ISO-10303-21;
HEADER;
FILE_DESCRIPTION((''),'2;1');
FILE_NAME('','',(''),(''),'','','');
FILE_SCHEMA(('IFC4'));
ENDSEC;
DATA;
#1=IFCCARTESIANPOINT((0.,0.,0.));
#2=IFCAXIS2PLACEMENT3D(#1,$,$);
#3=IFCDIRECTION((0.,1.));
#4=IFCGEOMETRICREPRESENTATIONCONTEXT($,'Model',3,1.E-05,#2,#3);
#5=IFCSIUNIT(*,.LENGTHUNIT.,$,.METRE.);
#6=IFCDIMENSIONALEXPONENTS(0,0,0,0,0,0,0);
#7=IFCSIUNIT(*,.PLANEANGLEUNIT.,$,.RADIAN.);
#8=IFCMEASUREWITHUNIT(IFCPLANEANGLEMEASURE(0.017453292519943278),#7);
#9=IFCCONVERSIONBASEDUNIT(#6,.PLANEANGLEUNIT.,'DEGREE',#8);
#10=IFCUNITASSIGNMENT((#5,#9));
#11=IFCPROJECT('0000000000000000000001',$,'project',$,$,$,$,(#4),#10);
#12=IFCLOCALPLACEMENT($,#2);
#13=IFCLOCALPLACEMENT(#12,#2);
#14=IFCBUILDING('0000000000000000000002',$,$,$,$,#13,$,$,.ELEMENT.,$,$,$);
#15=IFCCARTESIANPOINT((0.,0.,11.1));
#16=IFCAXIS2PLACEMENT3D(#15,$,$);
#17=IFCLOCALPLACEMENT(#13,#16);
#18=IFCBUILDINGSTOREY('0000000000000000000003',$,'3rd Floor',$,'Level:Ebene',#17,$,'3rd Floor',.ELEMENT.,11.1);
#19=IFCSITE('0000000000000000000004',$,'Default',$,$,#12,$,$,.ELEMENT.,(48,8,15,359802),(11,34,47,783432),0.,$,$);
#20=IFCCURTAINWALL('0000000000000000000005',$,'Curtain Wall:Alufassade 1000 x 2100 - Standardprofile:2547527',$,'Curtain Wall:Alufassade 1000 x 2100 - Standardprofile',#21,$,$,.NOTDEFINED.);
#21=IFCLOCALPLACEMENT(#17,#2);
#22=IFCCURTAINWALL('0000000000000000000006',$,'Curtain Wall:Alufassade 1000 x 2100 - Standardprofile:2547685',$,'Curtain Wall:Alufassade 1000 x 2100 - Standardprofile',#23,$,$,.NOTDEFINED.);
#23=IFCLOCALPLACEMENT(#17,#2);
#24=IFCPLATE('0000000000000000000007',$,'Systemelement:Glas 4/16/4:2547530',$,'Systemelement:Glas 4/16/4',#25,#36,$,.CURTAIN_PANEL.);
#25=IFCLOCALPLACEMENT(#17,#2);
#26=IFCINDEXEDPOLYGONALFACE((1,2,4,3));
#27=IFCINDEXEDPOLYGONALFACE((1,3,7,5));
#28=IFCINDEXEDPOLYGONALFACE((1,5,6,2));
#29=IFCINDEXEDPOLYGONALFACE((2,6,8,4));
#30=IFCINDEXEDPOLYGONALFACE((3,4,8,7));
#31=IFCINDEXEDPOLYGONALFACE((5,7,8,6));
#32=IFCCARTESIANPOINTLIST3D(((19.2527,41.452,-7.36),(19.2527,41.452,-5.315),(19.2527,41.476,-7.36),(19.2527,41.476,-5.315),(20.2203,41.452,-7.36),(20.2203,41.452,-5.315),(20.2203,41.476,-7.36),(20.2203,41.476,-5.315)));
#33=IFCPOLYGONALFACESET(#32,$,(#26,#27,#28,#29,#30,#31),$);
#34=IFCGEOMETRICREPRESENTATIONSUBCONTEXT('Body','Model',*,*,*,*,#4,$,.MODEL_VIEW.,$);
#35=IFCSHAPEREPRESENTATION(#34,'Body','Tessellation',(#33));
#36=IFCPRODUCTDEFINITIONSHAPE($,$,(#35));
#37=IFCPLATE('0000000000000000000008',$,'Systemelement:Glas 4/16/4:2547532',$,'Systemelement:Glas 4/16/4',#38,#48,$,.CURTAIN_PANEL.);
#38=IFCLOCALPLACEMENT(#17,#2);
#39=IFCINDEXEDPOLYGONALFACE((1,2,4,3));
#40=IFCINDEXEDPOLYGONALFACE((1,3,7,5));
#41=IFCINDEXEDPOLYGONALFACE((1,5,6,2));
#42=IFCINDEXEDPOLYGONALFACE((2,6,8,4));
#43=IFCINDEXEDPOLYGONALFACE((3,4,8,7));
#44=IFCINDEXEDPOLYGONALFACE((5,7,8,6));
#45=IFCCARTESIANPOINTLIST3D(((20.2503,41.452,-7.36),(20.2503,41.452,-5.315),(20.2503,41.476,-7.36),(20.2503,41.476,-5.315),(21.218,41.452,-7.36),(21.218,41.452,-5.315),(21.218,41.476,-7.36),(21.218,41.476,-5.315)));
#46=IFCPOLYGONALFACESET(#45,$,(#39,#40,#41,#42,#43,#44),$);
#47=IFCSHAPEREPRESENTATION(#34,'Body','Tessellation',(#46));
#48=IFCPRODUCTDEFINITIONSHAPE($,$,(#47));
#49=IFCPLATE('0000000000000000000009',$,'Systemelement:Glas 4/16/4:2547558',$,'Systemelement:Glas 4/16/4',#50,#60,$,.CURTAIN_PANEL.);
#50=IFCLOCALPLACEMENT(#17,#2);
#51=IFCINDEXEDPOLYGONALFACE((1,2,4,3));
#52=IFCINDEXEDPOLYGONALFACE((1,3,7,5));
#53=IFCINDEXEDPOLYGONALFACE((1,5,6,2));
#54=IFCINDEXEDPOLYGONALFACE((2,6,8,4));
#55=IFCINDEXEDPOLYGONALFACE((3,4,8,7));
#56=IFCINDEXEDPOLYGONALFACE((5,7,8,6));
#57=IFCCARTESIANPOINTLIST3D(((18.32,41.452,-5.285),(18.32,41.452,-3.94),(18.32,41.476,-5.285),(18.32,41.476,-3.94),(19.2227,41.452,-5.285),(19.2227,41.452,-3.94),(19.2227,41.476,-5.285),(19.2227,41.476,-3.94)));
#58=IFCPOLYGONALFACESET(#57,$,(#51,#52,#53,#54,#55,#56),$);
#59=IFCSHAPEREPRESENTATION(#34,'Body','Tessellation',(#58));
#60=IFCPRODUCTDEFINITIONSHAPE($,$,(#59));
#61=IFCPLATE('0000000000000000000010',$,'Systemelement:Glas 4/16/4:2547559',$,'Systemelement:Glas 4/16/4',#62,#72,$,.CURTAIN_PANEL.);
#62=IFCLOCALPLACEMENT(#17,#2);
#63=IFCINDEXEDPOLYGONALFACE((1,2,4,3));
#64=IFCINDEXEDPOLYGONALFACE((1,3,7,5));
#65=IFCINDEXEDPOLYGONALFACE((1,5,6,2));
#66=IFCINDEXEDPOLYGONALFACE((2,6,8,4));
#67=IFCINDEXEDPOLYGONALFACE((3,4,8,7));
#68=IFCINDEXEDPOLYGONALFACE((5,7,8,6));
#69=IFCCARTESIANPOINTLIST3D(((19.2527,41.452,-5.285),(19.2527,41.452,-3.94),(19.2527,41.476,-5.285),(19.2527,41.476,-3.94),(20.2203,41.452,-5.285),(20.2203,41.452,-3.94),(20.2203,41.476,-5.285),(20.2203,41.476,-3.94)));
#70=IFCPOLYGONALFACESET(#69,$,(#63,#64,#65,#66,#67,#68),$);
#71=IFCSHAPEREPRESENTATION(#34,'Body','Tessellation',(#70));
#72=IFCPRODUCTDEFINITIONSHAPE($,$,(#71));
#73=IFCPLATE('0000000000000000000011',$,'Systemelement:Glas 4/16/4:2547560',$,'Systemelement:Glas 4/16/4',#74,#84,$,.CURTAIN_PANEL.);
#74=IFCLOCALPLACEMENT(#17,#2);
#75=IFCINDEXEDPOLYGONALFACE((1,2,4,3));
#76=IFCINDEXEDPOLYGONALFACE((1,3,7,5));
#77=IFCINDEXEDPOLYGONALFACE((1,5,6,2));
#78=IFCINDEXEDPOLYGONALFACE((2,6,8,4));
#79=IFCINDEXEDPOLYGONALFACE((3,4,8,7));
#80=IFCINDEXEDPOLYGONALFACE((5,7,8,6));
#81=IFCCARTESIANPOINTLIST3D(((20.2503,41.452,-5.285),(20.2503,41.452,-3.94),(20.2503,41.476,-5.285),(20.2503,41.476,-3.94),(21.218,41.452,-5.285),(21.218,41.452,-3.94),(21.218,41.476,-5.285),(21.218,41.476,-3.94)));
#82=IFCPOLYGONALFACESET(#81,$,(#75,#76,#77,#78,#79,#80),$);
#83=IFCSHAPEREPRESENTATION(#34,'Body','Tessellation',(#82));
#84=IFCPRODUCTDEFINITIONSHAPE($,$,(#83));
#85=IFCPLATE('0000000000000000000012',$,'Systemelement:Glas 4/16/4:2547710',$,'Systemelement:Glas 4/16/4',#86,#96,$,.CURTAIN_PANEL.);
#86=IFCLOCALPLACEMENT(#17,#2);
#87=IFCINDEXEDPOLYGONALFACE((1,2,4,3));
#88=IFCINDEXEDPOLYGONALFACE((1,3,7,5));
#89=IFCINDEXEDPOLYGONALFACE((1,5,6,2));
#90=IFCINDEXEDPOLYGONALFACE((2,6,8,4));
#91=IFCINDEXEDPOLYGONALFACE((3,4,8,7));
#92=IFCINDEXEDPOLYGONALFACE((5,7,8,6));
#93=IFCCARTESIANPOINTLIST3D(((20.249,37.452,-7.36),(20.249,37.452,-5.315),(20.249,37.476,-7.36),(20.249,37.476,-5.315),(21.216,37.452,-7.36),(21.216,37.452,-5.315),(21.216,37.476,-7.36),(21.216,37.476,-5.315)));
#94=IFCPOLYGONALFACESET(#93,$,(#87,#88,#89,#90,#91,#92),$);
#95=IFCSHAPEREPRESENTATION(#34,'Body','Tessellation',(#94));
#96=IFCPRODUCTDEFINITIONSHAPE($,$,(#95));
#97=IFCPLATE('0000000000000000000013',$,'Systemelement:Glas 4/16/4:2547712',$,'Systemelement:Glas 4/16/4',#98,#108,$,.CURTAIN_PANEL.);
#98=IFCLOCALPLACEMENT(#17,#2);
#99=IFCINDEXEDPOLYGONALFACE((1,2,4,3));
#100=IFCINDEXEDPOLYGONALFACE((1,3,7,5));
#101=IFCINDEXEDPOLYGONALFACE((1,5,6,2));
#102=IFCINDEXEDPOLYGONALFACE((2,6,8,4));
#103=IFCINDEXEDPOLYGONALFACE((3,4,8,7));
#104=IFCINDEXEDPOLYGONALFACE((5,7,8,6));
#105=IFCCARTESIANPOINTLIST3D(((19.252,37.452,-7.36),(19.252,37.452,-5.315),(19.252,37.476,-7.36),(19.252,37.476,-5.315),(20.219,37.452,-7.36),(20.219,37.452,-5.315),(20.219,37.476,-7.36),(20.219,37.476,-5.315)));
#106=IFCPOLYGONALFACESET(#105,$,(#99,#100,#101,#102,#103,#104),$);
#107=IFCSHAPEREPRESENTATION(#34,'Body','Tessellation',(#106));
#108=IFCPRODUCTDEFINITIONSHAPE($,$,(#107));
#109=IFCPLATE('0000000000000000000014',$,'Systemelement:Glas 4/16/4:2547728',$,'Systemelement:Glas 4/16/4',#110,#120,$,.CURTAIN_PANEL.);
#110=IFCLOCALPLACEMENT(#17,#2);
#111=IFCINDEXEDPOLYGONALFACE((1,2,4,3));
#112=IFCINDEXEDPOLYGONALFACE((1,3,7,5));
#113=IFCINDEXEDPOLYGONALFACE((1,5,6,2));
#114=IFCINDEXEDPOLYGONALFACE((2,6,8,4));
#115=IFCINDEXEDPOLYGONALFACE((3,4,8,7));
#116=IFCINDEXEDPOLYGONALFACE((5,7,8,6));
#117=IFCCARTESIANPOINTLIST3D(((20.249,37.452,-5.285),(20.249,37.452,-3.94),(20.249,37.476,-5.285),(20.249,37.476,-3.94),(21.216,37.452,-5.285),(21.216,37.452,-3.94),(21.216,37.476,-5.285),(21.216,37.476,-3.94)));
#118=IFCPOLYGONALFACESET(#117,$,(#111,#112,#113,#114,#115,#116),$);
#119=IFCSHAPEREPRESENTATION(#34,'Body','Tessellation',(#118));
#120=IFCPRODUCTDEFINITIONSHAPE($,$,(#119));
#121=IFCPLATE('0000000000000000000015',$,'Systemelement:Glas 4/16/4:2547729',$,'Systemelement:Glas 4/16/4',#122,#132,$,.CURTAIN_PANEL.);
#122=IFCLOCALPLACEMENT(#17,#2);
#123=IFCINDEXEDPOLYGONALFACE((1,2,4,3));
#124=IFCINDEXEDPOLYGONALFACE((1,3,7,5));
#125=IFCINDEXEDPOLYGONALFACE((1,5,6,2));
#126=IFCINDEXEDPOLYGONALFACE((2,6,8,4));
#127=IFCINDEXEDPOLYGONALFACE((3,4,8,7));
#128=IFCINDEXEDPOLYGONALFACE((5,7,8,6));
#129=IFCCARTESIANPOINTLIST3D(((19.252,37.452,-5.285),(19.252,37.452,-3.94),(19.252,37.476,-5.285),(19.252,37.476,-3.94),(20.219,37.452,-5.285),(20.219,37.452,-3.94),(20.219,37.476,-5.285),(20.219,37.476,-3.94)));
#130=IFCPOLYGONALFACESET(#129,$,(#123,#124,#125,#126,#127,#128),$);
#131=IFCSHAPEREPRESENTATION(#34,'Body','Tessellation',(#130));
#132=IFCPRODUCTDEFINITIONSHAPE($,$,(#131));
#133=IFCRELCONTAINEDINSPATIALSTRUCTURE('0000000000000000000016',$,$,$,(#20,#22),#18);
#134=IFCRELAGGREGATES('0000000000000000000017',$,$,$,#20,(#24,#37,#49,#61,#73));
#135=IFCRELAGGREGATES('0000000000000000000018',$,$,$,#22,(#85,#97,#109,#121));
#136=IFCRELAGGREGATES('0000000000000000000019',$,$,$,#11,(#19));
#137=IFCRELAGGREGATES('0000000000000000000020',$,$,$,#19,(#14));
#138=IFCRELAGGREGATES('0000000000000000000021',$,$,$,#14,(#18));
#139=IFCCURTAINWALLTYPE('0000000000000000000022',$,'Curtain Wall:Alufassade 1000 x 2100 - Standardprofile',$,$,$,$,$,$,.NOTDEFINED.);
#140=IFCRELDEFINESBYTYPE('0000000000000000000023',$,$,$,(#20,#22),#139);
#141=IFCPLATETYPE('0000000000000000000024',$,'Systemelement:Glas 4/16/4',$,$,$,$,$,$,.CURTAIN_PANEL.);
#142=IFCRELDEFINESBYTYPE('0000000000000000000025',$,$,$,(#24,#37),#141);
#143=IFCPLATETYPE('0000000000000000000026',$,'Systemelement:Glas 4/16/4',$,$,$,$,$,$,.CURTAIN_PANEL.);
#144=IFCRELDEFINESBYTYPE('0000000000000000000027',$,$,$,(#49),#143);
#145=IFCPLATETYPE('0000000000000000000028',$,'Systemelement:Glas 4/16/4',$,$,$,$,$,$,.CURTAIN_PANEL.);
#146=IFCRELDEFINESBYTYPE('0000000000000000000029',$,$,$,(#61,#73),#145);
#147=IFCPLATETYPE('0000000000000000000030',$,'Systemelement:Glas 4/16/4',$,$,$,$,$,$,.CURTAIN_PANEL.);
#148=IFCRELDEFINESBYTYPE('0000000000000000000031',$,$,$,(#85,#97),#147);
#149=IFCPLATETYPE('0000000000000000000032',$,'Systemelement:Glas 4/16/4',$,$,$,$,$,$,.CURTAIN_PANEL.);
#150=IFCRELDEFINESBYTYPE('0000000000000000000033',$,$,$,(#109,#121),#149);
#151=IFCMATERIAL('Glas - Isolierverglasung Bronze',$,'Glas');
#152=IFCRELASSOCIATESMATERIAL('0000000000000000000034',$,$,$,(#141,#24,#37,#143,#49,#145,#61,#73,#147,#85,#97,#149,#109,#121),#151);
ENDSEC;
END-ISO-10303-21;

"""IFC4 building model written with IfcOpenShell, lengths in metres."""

from ifc_helpers import new_model, entity, si_unit, converted_unit, direction, frame, origin, place, context, subcontext, project, spatial, indexed_curve, outline, extrude, source, transform, mapped, material, type_object, type_shapes, element, aggregate, save


model = new_model("IFC4")

# Units and contexts
model_context = context("Model", 3, precision=1e-05, world=origin(), true_north=direction((0.0, 1.0)))
body_context = subcontext(model_context, "Body", "Model", "MODEL_VIEW")
ifc_project = project(units=[si_unit("LENGTHUNIT", "METRE"), converted_unit("PLANEANGLEUNIT", "DEGREE", entity("IfcPlaneAngleMeasure", 0.017453292519943278), si_unit("PLANEANGLEUNIT", "RADIAN"), dimensions=[0, 0, 0, 0, 0, 0, 0])], contexts=[model_context])

# Site, building, storey
site_placement = place(None, origin())
site = spatial("IfcSite", under=ifc_project, at=site_placement, Name="Default", CompositionType="ELEMENT", RefLatitude=(48, 8, 15, 359802), RefLongitude=(11, 34, 47, 783432), RefElevation=0.0)
building_placement = place(site_placement, origin())
building = spatial("IfcBuilding", under=site, at=building_placement, CompositionType="ELEMENT")
storey_placement = place(building_placement, frame((0.0, 0.0, 11.1)))
storey = spatial("IfcBuildingStorey", under=building, at=storey_placement, Name="3rd Floor", ObjectType="Level:Ebene", LongName="3rd Floor", CompositionType="ELEMENT", Elevation=11.1)

# Curtain walls
curtain_wall_type = type_object("IfcCurtainWallType", Name="Curtain Wall:Alufassade 1000 x 2100 - Standardprofile", PredefinedType="NOTDEFINED")
curtain_wall_1_placement = place(storey_placement, frame((0.0, 0.0, -11.1)))
curtain_wall_1 = element("IfcCurtainWall", 1, at=curtain_wall_1_placement, inside=storey, type_object=curtain_wall_type, Name="Curtain Wall:Alufassade 1000 x 2100 - Standardprofile:2547527", ObjectType="Curtain Wall:Alufassade 1000 x 2100 - Standardprofile", PredefinedType="NOTDEFINED")
curtain_wall_2_placement = place(storey_placement, frame((0.0, 0.0, -11.1)))
curtain_wall_2 = element("IfcCurtainWall", 2, at=curtain_wall_2_placement, inside=storey, type_object=curtain_wall_type, Name="Curtain Wall:Alufassade 1000 x 2100 - Standardprofile:2547685", ObjectType="Curtain Wall:Alufassade 1000 x 2100 - Standardprofile", PredefinedType="NOTDEFINED")

# Plates
ifc_material_1 = material(Name="Glas - Isolierverglasung Bronze", Category="Glas")
plate_type_1 = type_object("IfcPlateType", Name="Systemelement:Glas 4/16/4", PredefinedType="CURTAIN_PANEL", material=ifc_material_1)
shared_shape_1 = source(origin(), body_context, "Body", "SweptSolid", [
    extrude(outline(indexed_curve([(-0.012, -0.4838), (0.012, -0.4838), (0.012, 0.4838), (-0.012, 0.4838), (-0.012, -0.4838)], self_intersect=False)), frame((0.0, 0.0, 0.0), z_axis=(0.0, 0.0, 1.0), x_axis=(0.0, 1.0, 0.0)), (0.0, 0.0, 1.0), 2.045),
])
type_shapes(plate_type_1, [shared_shape_1])
plate_1_placement = place(curtain_wall_1_placement, frame((19.7365, 41.464, 3.74)))
plate_1 = element("IfcPlate", 3, at=plate_1_placement, type_object=plate_type_1, material=ifc_material_1, Name="Systemelement:Glas 4/16/4:2547530", ObjectType="Systemelement:Glas 4/16/4", PredefinedType="CURTAIN_PANEL", context=body_context, shape_type="MappedRepresentation", body=[
    mapped(shared_shape_1, transform((0.0, 0.0, 0.0), scale=1.0)),
])
plate_2_placement = place(curtain_wall_1_placement, frame((20.7342, 41.464, 3.74)))
plate_2 = element("IfcPlate", 4, at=plate_2_placement, type_object=plate_type_1, material=ifc_material_1, Name="Systemelement:Glas 4/16/4:2547532", ObjectType="Systemelement:Glas 4/16/4", PredefinedType="CURTAIN_PANEL", context=body_context, shape_type="MappedRepresentation", body=[
    mapped(shared_shape_1, transform((0.0, 0.0, 0.0), scale=1.0)),
])
plate_type_2 = type_object("IfcPlateType", Name="Systemelement:Glas 4/16/4", PredefinedType="CURTAIN_PANEL", material=ifc_material_1)
shared_shape_2 = source(origin(), body_context, "Body", "SweptSolid", [
    extrude(outline(indexed_curve([(-0.012, -0.4513), (0.012, -0.4513), (0.012, 0.4513), (-0.012, 0.4513), (-0.012, -0.4513)], self_intersect=False)), frame((0.0, 0.0, 0.0), z_axis=(0.0, 0.0, 1.0), x_axis=(0.0, 1.0, 0.0)), (0.0, 0.0, 1.0), 1.345),
])
type_shapes(plate_type_2, [shared_shape_2])
plate_3_placement = place(curtain_wall_1_placement, frame((18.7713, 41.464, 5.815)))
plate_3 = element("IfcPlate", 5, at=plate_3_placement, type_object=plate_type_2, material=ifc_material_1, Name="Systemelement:Glas 4/16/4:2547558", ObjectType="Systemelement:Glas 4/16/4", PredefinedType="CURTAIN_PANEL", context=body_context, shape_type="MappedRepresentation", body=[
    mapped(shared_shape_2, transform((0.0, 0.0, 0.0), scale=1.0)),
])
plate_type_3 = type_object("IfcPlateType", Name="Systemelement:Glas 4/16/4", PredefinedType="CURTAIN_PANEL", material=ifc_material_1)
shared_shape_3 = source(origin(), body_context, "Body", "SweptSolid", [
    extrude(outline(indexed_curve([(-0.012, -0.4838), (0.012, -0.4838), (0.012, 0.4838), (-0.012, 0.4838), (-0.012, -0.4838)], self_intersect=False)), frame((0.0, 0.0, 0.0), z_axis=(0.0, 0.0, 1.0), x_axis=(0.0, 1.0, 0.0)), (0.0, 0.0, 1.0), 1.345),
])
type_shapes(plate_type_3, [shared_shape_3])
plate_4_placement = place(curtain_wall_1_placement, frame((19.7365, 41.464, 5.815)))
plate_4 = element("IfcPlate", 6, at=plate_4_placement, type_object=plate_type_3, material=ifc_material_1, Name="Systemelement:Glas 4/16/4:2547559", ObjectType="Systemelement:Glas 4/16/4", PredefinedType="CURTAIN_PANEL", context=body_context, shape_type="MappedRepresentation", body=[
    mapped(shared_shape_3, transform((0.0, 0.0, 0.0), scale=1.0)),
])
plate_5_placement = place(curtain_wall_1_placement, frame((20.7342, 41.464, 5.815)))
plate_5 = element("IfcPlate", 7, at=plate_5_placement, type_object=plate_type_3, material=ifc_material_1, Name="Systemelement:Glas 4/16/4:2547560", ObjectType="Systemelement:Glas 4/16/4", PredefinedType="CURTAIN_PANEL", context=body_context, shape_type="MappedRepresentation", body=[
    mapped(shared_shape_3, transform((0.0, 0.0, 0.0), scale=1.0)),
])
aggregate(curtain_wall_1, [plate_1, plate_2, plate_3, plate_4, plate_5])
plate_type_4 = type_object("IfcPlateType", Name="Systemelement:Glas 4/16/4", PredefinedType="CURTAIN_PANEL", material=ifc_material_1)
shared_shape_4 = source(origin(), body_context, "Body", "SweptSolid", [
    extrude(outline(indexed_curve([(-0.012, -0.4835), (0.012, -0.4835), (0.012, 0.4835), (-0.012, 0.4835), (-0.012, -0.4835)], self_intersect=False)), frame((0.0, 0.0, 0.0), z_axis=(0.0, 0.0, 1.0), x_axis=(0.0, 1.0, 0.0)), (0.0, 0.0, 1.0), 2.045),
])
type_shapes(plate_type_4, [shared_shape_4])
plate_6_placement = place(curtain_wall_2_placement, frame((20.7325, 37.464, 3.74), z_axis=(0.0, 0.0, 1.0), x_axis=(-1.0, 0.0, 0.0)))
plate_6 = element("IfcPlate", 8, at=plate_6_placement, type_object=plate_type_4, material=ifc_material_1, Name="Systemelement:Glas 4/16/4:2547710", ObjectType="Systemelement:Glas 4/16/4", PredefinedType="CURTAIN_PANEL", context=body_context, shape_type="MappedRepresentation", body=[
    mapped(shared_shape_4, transform((0.0, 0.0, 0.0), scale=1.0)),
])
plate_7_placement = place(curtain_wall_2_placement, frame((19.7355, 37.464, 3.74), z_axis=(0.0, 0.0, 1.0), x_axis=(-1.0, 0.0, 0.0)))
plate_7 = element("IfcPlate", 9, at=plate_7_placement, type_object=plate_type_4, material=ifc_material_1, Name="Systemelement:Glas 4/16/4:2547712", ObjectType="Systemelement:Glas 4/16/4", PredefinedType="CURTAIN_PANEL", context=body_context, shape_type="MappedRepresentation", body=[
    mapped(shared_shape_4, transform((0.0, 0.0, 0.0), scale=1.0)),
])
plate_type_5 = type_object("IfcPlateType", Name="Systemelement:Glas 4/16/4", PredefinedType="CURTAIN_PANEL", material=ifc_material_1)
shared_shape_5 = source(origin(), body_context, "Body", "SweptSolid", [
    extrude(outline(indexed_curve([(-0.012, -0.4835), (0.012, -0.4835), (0.012, 0.4835), (-0.012, 0.4835), (-0.012, -0.4835)], self_intersect=False)), frame((0.0, 0.0, 0.0), z_axis=(0.0, 0.0, 1.0), x_axis=(0.0, 1.0, 0.0)), (0.0, 0.0, 1.0), 1.345),
])
type_shapes(plate_type_5, [shared_shape_5])
plate_8_placement = place(curtain_wall_2_placement, frame((20.7325, 37.464, 5.815), z_axis=(0.0, 0.0, 1.0), x_axis=(-1.0, 0.0, 0.0)))
plate_8 = element("IfcPlate", 10, at=plate_8_placement, type_object=plate_type_5, material=ifc_material_1, Name="Systemelement:Glas 4/16/4:2547728", ObjectType="Systemelement:Glas 4/16/4", PredefinedType="CURTAIN_PANEL", context=body_context, shape_type="MappedRepresentation", body=[
    mapped(shared_shape_5, transform((0.0, 0.0, 0.0), scale=1.0)),
])
plate_9_placement = place(curtain_wall_2_placement, frame((19.7355, 37.464, 5.815), z_axis=(0.0, 0.0, 1.0), x_axis=(-1.0, 0.0, 0.0)))
plate_9 = element("IfcPlate", 11, at=plate_9_placement, type_object=plate_type_5, material=ifc_material_1, Name="Systemelement:Glas 4/16/4:2547729", ObjectType="Systemelement:Glas 4/16/4", PredefinedType="CURTAIN_PANEL", context=body_context, shape_type="MappedRepresentation", body=[
    mapped(shared_shape_5, transform((0.0, 0.0, 0.0), scale=1.0)),
])
aggregate(curtain_wall_2, [plate_6, plate_7, plate_8, plate_9])

save(model, "model.ifc")
